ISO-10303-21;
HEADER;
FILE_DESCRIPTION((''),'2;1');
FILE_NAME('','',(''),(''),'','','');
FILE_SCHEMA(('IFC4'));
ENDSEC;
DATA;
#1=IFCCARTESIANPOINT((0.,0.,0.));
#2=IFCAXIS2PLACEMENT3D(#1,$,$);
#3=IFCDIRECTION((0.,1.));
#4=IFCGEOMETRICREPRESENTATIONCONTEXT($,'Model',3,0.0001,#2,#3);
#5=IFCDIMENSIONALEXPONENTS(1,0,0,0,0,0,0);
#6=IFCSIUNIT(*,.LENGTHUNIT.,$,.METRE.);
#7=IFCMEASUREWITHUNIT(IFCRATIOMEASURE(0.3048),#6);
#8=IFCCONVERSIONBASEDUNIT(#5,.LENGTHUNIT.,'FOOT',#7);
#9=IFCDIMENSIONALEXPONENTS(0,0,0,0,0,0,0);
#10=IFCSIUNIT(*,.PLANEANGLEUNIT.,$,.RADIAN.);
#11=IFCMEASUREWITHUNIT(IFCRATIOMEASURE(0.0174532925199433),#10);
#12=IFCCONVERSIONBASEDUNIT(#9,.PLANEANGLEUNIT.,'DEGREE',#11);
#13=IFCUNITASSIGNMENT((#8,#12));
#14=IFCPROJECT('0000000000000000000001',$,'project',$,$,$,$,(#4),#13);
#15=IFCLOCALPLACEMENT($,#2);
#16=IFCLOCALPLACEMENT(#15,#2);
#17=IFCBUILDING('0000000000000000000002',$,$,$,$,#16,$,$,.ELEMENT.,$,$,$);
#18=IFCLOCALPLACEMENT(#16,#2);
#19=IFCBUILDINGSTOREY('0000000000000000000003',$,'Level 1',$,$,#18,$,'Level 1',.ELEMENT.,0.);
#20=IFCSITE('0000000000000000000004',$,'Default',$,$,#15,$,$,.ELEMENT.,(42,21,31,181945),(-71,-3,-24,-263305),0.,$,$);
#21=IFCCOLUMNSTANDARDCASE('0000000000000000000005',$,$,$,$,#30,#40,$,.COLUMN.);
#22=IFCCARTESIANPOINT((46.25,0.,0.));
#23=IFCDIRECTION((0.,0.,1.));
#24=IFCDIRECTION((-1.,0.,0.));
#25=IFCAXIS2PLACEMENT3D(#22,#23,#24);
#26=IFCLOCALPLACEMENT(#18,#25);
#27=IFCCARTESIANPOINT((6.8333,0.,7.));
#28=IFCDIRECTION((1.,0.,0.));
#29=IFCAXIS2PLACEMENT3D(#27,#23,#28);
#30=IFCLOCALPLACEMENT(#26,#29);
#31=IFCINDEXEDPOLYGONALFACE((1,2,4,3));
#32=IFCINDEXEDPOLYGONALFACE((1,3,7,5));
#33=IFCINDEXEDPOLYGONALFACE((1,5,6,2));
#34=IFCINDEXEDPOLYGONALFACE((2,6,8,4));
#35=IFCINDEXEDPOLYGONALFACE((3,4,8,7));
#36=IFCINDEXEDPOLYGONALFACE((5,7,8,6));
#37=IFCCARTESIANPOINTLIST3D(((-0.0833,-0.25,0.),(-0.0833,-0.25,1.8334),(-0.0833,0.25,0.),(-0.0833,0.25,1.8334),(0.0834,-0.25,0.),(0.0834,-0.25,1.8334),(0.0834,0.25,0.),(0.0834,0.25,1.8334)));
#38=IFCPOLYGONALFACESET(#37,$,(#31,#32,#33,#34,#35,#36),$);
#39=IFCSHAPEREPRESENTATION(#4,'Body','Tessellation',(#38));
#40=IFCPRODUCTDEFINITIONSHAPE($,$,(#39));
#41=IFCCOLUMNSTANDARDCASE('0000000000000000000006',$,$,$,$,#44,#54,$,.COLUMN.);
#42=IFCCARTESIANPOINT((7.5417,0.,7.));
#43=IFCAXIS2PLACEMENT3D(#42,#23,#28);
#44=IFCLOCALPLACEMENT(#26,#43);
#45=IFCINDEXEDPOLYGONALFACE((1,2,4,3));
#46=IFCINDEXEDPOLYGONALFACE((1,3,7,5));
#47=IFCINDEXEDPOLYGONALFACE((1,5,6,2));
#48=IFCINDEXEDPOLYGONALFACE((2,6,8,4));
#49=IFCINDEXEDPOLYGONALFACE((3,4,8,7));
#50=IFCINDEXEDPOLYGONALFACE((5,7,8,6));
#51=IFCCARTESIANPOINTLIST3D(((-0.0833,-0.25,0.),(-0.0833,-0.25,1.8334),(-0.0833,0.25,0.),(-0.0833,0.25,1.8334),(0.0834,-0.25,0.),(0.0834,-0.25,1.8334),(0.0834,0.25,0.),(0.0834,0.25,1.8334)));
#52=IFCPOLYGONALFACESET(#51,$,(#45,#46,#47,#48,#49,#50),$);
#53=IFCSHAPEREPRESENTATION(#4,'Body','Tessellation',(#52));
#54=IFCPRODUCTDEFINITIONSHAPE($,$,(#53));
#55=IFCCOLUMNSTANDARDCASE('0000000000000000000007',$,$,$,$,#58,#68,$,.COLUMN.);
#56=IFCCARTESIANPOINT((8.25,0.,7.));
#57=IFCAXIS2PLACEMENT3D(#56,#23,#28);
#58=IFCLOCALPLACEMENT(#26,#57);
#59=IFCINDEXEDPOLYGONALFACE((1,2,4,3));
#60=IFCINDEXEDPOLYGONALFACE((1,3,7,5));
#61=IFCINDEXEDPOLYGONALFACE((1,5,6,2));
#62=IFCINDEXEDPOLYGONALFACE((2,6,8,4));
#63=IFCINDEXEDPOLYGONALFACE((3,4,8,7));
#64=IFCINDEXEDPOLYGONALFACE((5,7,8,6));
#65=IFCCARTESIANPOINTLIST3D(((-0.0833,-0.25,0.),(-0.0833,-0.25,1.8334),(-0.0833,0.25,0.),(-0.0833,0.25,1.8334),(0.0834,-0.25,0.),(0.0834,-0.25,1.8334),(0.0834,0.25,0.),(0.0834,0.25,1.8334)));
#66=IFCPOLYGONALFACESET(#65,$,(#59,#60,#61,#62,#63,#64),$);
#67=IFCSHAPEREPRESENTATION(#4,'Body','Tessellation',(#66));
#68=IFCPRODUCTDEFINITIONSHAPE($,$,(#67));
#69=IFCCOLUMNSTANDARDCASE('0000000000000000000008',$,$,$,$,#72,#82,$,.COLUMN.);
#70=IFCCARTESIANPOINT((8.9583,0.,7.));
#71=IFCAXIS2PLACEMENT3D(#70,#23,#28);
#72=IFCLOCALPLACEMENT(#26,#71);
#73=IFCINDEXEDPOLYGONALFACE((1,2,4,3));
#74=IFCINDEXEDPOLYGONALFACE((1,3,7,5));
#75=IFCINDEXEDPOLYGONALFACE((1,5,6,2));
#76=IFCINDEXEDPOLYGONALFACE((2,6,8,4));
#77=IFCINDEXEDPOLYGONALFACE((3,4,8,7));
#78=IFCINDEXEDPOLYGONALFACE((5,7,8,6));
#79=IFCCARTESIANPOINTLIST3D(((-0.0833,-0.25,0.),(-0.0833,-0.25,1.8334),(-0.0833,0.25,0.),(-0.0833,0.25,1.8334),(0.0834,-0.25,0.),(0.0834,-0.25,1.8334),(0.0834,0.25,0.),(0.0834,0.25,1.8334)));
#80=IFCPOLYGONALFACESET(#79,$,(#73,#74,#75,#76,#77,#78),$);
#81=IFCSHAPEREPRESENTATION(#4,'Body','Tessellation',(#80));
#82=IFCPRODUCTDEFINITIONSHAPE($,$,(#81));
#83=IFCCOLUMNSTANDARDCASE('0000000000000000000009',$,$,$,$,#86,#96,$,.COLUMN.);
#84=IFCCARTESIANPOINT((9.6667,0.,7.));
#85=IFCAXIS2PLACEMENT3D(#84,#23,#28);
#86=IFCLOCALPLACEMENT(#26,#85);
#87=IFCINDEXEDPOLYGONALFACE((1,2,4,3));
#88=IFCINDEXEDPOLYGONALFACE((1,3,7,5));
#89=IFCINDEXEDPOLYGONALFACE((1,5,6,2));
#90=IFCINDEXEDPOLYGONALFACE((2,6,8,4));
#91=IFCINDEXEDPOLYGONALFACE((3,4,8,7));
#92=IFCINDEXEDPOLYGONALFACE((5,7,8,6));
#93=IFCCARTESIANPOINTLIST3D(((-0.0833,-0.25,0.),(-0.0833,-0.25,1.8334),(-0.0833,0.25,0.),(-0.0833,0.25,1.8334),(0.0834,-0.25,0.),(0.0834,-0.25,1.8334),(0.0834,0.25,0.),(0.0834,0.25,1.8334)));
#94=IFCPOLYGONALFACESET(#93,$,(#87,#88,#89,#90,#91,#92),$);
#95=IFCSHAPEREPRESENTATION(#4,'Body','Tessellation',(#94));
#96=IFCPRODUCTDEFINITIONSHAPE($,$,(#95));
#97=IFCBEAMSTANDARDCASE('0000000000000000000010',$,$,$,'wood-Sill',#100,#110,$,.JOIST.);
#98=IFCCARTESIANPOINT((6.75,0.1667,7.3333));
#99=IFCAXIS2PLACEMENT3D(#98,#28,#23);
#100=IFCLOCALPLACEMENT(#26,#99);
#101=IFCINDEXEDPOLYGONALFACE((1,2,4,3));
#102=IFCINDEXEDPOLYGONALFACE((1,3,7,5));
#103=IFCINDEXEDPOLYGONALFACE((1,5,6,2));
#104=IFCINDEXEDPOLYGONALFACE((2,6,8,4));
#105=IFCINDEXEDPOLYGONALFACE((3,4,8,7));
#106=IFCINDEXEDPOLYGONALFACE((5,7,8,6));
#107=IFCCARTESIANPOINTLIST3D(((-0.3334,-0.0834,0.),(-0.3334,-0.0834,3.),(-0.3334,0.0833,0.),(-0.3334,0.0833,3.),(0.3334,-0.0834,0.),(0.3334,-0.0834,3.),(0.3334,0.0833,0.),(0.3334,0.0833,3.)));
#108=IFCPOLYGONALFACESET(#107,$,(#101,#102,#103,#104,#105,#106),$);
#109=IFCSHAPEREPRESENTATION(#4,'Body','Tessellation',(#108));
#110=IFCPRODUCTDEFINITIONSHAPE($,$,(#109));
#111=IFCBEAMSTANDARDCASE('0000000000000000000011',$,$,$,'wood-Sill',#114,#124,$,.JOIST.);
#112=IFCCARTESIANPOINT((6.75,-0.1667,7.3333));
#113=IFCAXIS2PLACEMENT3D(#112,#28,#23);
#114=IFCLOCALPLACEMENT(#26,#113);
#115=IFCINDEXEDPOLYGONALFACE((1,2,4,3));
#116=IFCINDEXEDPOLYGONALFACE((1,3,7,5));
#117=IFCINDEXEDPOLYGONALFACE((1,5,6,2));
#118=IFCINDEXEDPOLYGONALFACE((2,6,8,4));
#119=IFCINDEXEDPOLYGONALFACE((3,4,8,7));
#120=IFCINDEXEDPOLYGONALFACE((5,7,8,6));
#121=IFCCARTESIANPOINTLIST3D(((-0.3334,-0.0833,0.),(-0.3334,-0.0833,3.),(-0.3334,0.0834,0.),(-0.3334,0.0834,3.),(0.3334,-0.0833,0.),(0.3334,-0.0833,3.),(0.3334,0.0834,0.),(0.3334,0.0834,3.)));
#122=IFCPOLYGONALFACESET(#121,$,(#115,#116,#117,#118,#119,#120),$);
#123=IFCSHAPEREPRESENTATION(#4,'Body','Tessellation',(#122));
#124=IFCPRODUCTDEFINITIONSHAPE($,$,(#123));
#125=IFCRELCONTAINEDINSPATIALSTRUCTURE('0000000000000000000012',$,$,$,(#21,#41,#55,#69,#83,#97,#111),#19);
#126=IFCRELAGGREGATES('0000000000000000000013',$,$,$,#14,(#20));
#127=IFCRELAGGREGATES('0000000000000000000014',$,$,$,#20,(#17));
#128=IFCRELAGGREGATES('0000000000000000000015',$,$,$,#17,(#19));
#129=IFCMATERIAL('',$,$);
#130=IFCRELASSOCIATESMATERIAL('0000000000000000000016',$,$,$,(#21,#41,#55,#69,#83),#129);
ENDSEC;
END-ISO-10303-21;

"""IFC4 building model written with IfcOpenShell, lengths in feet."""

from ifc_helpers import new_model, entity, si_unit, converted_unit, direction, frame, origin, origin_with_axes, place, context, project, spatial, rectangle, extrude, material, element, save


model = new_model("IFC4")

# Units and contexts
model_context = context("Model", 3, precision=0.0001, world=origin(), true_north=direction((0.0, 1.0)))
ifc_project = project(units=[converted_unit("LENGTHUNIT", "FOOT", entity("IfcRatioMeasure", 0.3048), si_unit("LENGTHUNIT", "METRE"), dimensions=[1, 0, 0, 0, 0, 0, 0]), converted_unit("PLANEANGLEUNIT", "DEGREE", entity("IfcRatioMeasure", 0.0174532925199433), si_unit("PLANEANGLEUNIT", "RADIAN"), dimensions=[0, 0, 0, 0, 0, 0, 0])], contexts=[model_context])

# Site, building, storey
site_placement = place(None, origin())
site = spatial("IfcSite", under=ifc_project, at=site_placement, Name="Default", CompositionType="ELEMENT", RefLatitude=(42, 21, 31, 181945), RefLongitude=(-71, -3, -24, -263305), RefElevation=0.0)
building_placement = place(site_placement, origin())
building = spatial("IfcBuilding", under=site, at=building_placement, CompositionType="ELEMENT")
storey_placement = place(building_placement, origin())
storey = spatial("IfcBuildingStorey", under=building, at=storey_placement, Name="Level 1", LongName="Level 1", CompositionType="ELEMENT", Elevation=0.0)

# Columns
placement = place(storey_placement, frame((46.25, 0.0, 0.0), z_axis=(0.0, 0.0, 1.0), x_axis=(-1.0, 0.0, 0.0)))
ifc_material_1 = material(Name="")
for number, where, z_axis, x_axis in (
    (1, (6.8333, 0.0, 7.0), (0.0, 0.0, 1.0), (1.0, 0.0, 0.0)),
    (2, (7.5417, 0.0, 7.0), (0.0, 0.0, 1.0), (1.0, 0.0, 0.0)),
    (3, (8.25, 0.0, 7.0), (0.0, 0.0, 1.0), (1.0, 0.0, 0.0)),
    (4, (8.9583, 0.0, 7.0), (0.0, 0.0, 1.0), (1.0, 0.0, 0.0)),
    (5, (9.6667, 0.0, 7.0), (0.0, 0.0, 1.0), (1.0, 0.0, 0.0)),
):
    element("IfcColumnStandardCase", number, at=place(placement, frame(where, z_axis=z_axis, x_axis=x_axis)), inside=storey, material=ifc_material_1, PredefinedType="COLUMN", context=model_context, shape_type="SweptSolid", body=[
        extrude(rectangle(XDim=0.1667, YDim=0.5), origin(), (0.0, 0.0, 1.0), 1.8334),
    ])

# Beams
for number, where, z_axis, x_axis in (
    (6, (6.75, 0.1667, 7.3333), (1.0, 0.0, 0.0), (0.0, 0.0, 1.0)),
    (7, (6.75, -0.1667, 7.3333), (1.0, 0.0, 0.0), (0.0, 0.0, 1.0)),
):
    element("IfcBeamStandardCase", number, at=place(placement, frame(where, z_axis=z_axis, x_axis=x_axis)), inside=storey, ObjectType="wood-Sill", PredefinedType="JOIST", context=model_context, shape_type="SweptSolid", body=[
        extrude(rectangle(XDim=0.6667, YDim=0.1667), origin_with_axes(), (0.0, 0.0, 1.0), 3.0),
    ])

save(model, "model.ifc")
